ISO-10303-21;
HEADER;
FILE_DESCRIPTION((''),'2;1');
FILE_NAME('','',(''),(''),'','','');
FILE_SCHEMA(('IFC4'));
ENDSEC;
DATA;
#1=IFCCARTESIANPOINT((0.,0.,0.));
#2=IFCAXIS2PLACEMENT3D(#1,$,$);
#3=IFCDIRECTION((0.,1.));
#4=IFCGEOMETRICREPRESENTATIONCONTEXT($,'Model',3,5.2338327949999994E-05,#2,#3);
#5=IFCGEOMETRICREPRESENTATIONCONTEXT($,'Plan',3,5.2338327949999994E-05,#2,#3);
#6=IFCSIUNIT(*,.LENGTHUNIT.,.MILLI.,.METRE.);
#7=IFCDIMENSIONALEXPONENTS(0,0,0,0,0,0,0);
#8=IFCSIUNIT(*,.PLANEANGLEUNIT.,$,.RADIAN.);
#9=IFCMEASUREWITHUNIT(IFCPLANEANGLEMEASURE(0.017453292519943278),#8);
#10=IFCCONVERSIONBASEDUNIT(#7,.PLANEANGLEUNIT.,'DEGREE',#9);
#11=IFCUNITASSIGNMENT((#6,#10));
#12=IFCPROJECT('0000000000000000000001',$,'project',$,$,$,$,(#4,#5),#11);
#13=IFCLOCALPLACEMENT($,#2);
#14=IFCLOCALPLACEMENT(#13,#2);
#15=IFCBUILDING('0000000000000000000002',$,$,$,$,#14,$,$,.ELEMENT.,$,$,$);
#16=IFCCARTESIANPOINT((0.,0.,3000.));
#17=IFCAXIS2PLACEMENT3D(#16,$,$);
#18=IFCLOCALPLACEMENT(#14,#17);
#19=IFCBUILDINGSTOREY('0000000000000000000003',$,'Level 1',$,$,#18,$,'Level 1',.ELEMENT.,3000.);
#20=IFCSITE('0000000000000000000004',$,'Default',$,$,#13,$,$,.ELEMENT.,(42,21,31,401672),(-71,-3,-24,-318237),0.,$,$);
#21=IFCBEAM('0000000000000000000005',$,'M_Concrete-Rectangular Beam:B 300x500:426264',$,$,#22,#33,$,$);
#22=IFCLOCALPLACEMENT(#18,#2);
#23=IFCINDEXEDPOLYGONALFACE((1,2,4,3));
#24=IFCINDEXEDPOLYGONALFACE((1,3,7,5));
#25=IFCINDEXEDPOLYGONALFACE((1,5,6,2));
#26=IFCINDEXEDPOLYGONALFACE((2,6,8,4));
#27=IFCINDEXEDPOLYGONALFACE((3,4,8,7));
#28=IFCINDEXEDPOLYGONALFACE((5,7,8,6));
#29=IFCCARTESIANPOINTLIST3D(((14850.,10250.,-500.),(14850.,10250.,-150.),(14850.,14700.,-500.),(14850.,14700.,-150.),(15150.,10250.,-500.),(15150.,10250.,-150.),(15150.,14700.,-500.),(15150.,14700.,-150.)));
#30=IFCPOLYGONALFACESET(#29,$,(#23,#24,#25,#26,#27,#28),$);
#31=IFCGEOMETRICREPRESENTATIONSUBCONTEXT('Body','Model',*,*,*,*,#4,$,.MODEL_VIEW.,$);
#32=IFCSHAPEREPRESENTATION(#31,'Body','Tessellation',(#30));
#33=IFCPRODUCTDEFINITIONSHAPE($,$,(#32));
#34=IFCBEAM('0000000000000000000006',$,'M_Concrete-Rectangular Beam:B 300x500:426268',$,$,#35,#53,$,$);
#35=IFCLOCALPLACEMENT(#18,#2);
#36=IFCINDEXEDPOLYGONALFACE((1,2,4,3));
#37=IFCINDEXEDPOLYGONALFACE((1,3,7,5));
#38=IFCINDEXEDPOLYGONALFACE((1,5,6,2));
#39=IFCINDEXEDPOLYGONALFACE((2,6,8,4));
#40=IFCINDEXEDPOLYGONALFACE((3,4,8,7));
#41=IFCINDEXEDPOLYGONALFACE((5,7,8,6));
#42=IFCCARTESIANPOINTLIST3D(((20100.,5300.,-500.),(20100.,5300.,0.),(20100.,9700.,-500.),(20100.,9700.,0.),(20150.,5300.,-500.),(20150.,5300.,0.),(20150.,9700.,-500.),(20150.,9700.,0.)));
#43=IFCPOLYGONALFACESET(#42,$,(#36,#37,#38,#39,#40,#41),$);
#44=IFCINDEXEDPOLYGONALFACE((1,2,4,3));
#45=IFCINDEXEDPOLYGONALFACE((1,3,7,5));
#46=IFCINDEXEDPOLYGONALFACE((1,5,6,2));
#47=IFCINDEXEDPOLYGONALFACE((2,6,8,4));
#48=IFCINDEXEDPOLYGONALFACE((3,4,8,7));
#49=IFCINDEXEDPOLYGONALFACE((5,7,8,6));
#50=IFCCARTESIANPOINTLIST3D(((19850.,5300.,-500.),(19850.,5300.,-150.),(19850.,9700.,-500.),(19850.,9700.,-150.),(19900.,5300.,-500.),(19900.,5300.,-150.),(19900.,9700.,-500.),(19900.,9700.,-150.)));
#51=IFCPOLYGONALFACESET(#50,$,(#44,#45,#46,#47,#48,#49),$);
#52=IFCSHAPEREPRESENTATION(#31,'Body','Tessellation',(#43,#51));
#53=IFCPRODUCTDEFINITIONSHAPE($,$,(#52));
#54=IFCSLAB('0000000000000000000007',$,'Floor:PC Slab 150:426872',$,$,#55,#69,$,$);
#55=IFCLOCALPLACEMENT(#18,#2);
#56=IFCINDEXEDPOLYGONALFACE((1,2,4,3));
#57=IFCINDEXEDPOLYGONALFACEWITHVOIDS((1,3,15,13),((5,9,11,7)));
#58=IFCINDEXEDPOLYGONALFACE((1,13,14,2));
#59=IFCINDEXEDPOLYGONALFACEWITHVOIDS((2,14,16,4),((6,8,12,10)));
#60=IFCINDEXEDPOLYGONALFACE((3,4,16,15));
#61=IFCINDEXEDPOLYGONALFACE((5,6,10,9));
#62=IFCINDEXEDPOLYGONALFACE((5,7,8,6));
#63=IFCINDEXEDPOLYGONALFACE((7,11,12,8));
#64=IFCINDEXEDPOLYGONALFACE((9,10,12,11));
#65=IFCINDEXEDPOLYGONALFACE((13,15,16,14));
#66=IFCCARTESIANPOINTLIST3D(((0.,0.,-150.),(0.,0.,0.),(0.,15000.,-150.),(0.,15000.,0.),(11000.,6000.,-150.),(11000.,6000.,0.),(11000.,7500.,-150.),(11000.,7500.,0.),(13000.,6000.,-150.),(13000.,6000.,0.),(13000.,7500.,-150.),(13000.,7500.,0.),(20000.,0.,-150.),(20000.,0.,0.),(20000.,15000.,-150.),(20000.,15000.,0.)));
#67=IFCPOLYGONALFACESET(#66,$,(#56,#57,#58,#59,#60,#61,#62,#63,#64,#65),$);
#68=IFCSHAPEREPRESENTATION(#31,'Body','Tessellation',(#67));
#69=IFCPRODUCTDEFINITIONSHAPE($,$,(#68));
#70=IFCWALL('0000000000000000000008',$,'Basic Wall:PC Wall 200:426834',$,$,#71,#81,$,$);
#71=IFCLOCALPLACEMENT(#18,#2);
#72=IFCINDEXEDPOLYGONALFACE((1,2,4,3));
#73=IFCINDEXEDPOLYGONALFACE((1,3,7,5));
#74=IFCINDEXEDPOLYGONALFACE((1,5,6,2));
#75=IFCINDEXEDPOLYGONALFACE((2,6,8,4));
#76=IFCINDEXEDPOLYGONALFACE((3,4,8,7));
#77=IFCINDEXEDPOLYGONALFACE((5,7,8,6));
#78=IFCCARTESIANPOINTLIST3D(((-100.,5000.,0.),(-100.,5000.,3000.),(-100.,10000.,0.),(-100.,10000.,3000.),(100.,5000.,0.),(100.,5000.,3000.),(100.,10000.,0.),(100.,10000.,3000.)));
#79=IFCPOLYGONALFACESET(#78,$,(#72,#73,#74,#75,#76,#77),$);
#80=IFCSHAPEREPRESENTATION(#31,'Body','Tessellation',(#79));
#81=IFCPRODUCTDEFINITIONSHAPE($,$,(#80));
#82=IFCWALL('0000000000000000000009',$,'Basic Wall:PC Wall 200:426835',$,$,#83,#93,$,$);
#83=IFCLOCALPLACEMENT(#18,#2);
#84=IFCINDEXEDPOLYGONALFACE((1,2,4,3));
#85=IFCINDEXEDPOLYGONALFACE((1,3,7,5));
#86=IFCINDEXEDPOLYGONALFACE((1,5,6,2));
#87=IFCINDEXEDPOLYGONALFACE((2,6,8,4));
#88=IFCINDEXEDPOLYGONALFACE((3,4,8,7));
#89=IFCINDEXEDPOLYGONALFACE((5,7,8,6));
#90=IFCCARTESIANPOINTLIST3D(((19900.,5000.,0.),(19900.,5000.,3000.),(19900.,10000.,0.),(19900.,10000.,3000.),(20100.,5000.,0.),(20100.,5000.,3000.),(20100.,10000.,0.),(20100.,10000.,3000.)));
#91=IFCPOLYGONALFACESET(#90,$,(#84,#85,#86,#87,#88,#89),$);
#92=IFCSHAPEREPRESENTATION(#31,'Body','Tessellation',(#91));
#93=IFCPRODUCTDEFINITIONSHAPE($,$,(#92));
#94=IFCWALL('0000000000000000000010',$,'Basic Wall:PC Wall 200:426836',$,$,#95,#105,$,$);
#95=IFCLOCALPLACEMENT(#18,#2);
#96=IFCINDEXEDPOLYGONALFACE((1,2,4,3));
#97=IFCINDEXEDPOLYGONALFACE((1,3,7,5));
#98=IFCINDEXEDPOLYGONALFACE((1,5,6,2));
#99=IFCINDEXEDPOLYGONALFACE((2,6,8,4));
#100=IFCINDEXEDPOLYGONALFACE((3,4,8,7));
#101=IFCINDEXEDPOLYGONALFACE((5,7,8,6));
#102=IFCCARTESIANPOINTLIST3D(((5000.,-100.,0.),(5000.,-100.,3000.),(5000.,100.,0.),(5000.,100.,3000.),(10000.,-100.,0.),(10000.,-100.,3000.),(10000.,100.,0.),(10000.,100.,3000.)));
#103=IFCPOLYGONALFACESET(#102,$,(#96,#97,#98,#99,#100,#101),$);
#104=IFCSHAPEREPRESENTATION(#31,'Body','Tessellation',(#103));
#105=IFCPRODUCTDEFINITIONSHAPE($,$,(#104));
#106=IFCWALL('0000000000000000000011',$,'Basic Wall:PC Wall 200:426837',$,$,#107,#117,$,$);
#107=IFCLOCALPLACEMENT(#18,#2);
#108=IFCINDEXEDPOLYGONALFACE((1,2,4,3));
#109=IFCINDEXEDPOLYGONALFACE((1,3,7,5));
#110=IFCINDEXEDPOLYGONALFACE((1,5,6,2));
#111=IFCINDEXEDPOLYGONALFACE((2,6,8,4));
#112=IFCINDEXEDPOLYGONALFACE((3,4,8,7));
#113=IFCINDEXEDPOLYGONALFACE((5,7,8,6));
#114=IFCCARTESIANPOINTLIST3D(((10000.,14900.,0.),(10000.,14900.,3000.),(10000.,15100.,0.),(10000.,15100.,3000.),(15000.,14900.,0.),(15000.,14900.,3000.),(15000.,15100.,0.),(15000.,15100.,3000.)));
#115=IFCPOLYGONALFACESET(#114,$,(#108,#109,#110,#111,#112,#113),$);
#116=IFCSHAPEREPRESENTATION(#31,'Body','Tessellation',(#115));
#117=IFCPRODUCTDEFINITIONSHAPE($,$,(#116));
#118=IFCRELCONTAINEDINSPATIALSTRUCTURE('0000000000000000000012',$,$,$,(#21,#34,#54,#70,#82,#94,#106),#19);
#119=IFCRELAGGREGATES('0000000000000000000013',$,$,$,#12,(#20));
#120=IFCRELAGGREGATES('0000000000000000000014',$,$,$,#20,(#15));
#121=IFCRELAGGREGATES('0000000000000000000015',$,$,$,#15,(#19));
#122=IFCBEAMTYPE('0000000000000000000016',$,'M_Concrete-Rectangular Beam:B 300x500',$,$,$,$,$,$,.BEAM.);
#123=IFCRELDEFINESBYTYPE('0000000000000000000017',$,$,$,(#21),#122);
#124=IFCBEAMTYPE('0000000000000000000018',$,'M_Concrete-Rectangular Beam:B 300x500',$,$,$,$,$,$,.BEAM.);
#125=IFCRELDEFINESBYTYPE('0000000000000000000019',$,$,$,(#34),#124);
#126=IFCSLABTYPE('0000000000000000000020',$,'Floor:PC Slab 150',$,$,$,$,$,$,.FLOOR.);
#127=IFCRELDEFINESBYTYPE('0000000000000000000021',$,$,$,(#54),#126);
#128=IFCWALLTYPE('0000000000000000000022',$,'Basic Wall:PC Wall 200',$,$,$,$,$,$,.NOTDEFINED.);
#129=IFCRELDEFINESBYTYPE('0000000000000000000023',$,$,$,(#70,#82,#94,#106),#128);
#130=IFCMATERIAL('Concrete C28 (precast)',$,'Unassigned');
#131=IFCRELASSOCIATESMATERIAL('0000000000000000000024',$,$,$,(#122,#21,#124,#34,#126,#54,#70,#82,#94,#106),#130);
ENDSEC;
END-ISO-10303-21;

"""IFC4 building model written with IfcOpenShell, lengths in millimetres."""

from ifc_helpers import new_model, entity, si_unit, converted_unit, direction, frame, origin, place, context, subcontext, project, spatial, indexed_curve, outline, extrude, source, transform, mapped, material, type_object, type_shapes, element, save


model = new_model("IFC4")

# Units and contexts
model_context = context("Model", 3, precision=5.2338327949999994e-05, world=origin(), true_north=direction((0.0, 1.0)))
plan_context = context("Plan", 3, precision=5.2338327949999994e-05, world=origin(), true_north=direction((0.0, 1.0)))
body_context = subcontext(model_context, "Body", "Model", "MODEL_VIEW")
ifc_project = project(units=[si_unit("LENGTHUNIT", "METRE", prefix="MILLI"), converted_unit("PLANEANGLEUNIT", "DEGREE", entity("IfcPlaneAngleMeasure", 0.017453292519943278), si_unit("PLANEANGLEUNIT", "RADIAN"), dimensions=[0, 0, 0, 0, 0, 0, 0])], contexts=[model_context, plan_context])

# Site, building, storey
site_placement = place(None, origin())
site = spatial("IfcSite", under=ifc_project, at=site_placement, Name="Default", CompositionType="ELEMENT", RefLatitude=(42, 21, 31, 401672), RefLongitude=(-71, -3, -24, -318237), RefElevation=0.0)
building_placement = place(site_placement, origin())
building = spatial("IfcBuilding", under=site, at=building_placement, CompositionType="ELEMENT")
storey_placement = place(building_placement, frame((0.0, 0.0, 3000.0)))
storey = spatial("IfcBuildingStorey", under=building, at=storey_placement, Name="Level 1", LongName="Level 1", CompositionType="ELEMENT", Elevation=3000.0)

# Beams
ifc_material = material(Name="Concrete C28 (precast)", Category="Unassigned")
beam_type_1 = type_object("IfcBeamType", Name="M_Concrete-Rectangular Beam:B 300x500", PredefinedType="BEAM", material=ifc_material)
shared_shape_1 = source(origin(), body_context, "Body", "SweptSolid", [
    extrude(outline(indexed_curve([(-150.0, -175.0), (150.0, -175.0), (150.0, 175.0), (-150.0, 175.0), (-150.0, -175.0)], self_intersect=False)), frame((15000.0, 10250.0, 2675.0), z_axis=(0.0, 1.0, 0.0), x_axis=(-1.0, 0.0, 0.0)), (0.0, 0.0, 1.0), 4450.0),
])
type_shapes(beam_type_1, [shared_shape_1])
beam_1_placement = place(storey_placement, frame((0.0, 0.0, -3000.0)))
element("IfcBeam", 1, at=beam_1_placement, inside=storey, type_object=beam_type_1, material=ifc_material, Name="M_Concrete-Rectangular Beam:B 300x500:426264", context=body_context, shape_type="MappedRepresentation", body=[
    mapped(shared_shape_1, transform((0.0, 0.0, 0.0), scale=1.0)),
])
beam_type_2 = type_object("IfcBeamType", Name="M_Concrete-Rectangular Beam:B 300x500", PredefinedType="BEAM", material=ifc_material)
shared_shape_2 = source(origin(), body_context, "Body", "SweptSolid", [
    extrude(outline(indexed_curve([(-25.0, -250.0), (25.0, -250.0), (25.0, 250.0), (-25.0, 250.0), (-25.0, -250.0)], self_intersect=False)), frame((20125.0, 5300.0, 2750.0), z_axis=(0.0, 1.0, 0.0), x_axis=(-1.0, 0.0, 0.0)), (0.0, 0.0, 1.0), 4400.0),
    extrude(outline(indexed_curve([(-25.0, -175.0), (25.0, -175.0), (25.0, 175.0), (-25.0, 175.0), (-25.0, -175.0)], self_intersect=False)), frame((19875.0, 5300.0, 2675.0), z_axis=(0.0, 1.0, 0.0), x_axis=(-1.0, 0.0, 0.0)), (0.0, 0.0, 1.0), 4400.0),
])
type_shapes(beam_type_2, [shared_shape_2])
beam_2_placement = place(storey_placement, frame((0.0, 0.0, -3000.0)))
element("IfcBeam", 2, at=beam_2_placement, inside=storey, type_object=beam_type_2, material=ifc_material, Name="M_Concrete-Rectangular Beam:B 300x500:426268", context=body_context, shape_type="MappedRepresentation", body=[
    mapped(shared_shape_2, transform((0.0, 0.0, 0.0), scale=1.0)),
])

# Slab, opening
slab_type = type_object("IfcSlabType", Name="Floor:PC Slab 150", PredefinedType="FLOOR", material=ifc_material)
slab_placement = place(storey_placement, origin())
slab = element("IfcSlab", 3, at=slab_placement, inside=storey, type_object=slab_type, material=ifc_material, Name="Floor:PC Slab 150:426872", context=body_context, shape_type="SweptSolid", body=[
    extrude(outline(indexed_curve([(-7500.0, -10000.0), (7500.0, -10000.0), (7500.0, 10000.0), (-7500.0, 10000.0), (-7500.0, -10000.0)], self_intersect=False), holes=[indexed_curve([(-1500.0, -3000.0), (-1500.0, -1000.0), (0.0, -1000.0), (0.0, -3000.0), (-1500.0, -3000.0)], self_intersect=False)]), frame((10000.0, 7500.0, -150.0), z_axis=(0.0, 0.0, 1.0), x_axis=(0.0, 1.0, 0.0)), (0.0, 0.0, 1.0), 150.0),
])
opening_placement = place(slab_placement, origin())
element("IfcOpeningElement", 4, at=opening_placement, cuts=slab, PredefinedType="OPENING", context=body_context, shape_type="SweptSolid", body=[
    extrude(outline(indexed_curve([(13000.0, 6000.0), (13000.0, 7500.0), (11000.0, 7500.0), (11000.0, 6000.0), (13000.0, 6000.0)], self_intersect=False)), frame((0.0, 0.0, -3000.0)), (0.0, 0.0, 1.0), 20000.0),
])

# Walls
wall_type = type_object("IfcWallType", Name="Basic Wall:PC Wall 200", PredefinedType="NOTDEFINED")
wall_1_placement = place(storey_placement, frame((0.0, 5000.0, 0.0), z_axis=(0.0, 0.0, 1.0), x_axis=(0.0, 1.0, 0.0)))
element("IfcWall", 5, at=wall_1_placement, inside=storey, type_object=wall_type, material=ifc_material, Name="Basic Wall:PC Wall 200:426834", context=body_context, shape_type="SweptSolid", body=[
    extrude(outline(indexed_curve([(5000.0, 100.0), (0.0, 100.0), (0.0, -100.0), (5000.0, -100.0), (5000.0, 100.0)], self_intersect=False)), origin(), (0.0, 0.0, 1.0), 3000.0),
])
wall_2_placement = place(storey_placement, frame((20000.0, 5000.0, 0.0), z_axis=(0.0, 0.0, 1.0), x_axis=(0.0, 1.0, 0.0)))
element("IfcWall", 6, at=wall_2_placement, inside=storey, type_object=wall_type, material=ifc_material, Name="Basic Wall:PC Wall 200:426835", context=body_context, shape_type="SweptSolid", body=[
    extrude(outline(indexed_curve([(5000.0, 100.0), (0.0, 100.0), (0.0, -100.0), (5000.0, -100.0), (5000.0, 100.0)], self_intersect=False)), origin(), (0.0, 0.0, 1.0), 3000.0),
])
wall_3_placement = place(storey_placement, frame((5000.0, 0.0, 0.0)))
element("IfcWall", 7, at=wall_3_placement, inside=storey, type_object=wall_type, material=ifc_material, Name="Basic Wall:PC Wall 200:426836", context=body_context, shape_type="SweptSolid", body=[
    extrude(outline(indexed_curve([(5000.0, 100.0), (0.0, 100.0), (0.0, -100.0), (5000.0, -100.0), (5000.0, 100.0)], self_intersect=False)), origin(), (0.0, 0.0, 1.0), 3000.0),
])
wall_4_placement = place(storey_placement, frame((10000.0, 15000.0, 0.0)))
element("IfcWall", 8, at=wall_4_placement, inside=storey, type_object=wall_type, material=ifc_material, Name="Basic Wall:PC Wall 200:426837", context=body_context, shape_type="SweptSolid", body=[
    extrude(outline(indexed_curve([(5000.0, 100.0), (0.0, 100.0), (0.0, -100.0), (5000.0, -100.0), (5000.0, 100.0)], self_intersect=False)), origin(), (0.0, 0.0, 1.0), 3000.0),
])

save(model, "model.ifc")
